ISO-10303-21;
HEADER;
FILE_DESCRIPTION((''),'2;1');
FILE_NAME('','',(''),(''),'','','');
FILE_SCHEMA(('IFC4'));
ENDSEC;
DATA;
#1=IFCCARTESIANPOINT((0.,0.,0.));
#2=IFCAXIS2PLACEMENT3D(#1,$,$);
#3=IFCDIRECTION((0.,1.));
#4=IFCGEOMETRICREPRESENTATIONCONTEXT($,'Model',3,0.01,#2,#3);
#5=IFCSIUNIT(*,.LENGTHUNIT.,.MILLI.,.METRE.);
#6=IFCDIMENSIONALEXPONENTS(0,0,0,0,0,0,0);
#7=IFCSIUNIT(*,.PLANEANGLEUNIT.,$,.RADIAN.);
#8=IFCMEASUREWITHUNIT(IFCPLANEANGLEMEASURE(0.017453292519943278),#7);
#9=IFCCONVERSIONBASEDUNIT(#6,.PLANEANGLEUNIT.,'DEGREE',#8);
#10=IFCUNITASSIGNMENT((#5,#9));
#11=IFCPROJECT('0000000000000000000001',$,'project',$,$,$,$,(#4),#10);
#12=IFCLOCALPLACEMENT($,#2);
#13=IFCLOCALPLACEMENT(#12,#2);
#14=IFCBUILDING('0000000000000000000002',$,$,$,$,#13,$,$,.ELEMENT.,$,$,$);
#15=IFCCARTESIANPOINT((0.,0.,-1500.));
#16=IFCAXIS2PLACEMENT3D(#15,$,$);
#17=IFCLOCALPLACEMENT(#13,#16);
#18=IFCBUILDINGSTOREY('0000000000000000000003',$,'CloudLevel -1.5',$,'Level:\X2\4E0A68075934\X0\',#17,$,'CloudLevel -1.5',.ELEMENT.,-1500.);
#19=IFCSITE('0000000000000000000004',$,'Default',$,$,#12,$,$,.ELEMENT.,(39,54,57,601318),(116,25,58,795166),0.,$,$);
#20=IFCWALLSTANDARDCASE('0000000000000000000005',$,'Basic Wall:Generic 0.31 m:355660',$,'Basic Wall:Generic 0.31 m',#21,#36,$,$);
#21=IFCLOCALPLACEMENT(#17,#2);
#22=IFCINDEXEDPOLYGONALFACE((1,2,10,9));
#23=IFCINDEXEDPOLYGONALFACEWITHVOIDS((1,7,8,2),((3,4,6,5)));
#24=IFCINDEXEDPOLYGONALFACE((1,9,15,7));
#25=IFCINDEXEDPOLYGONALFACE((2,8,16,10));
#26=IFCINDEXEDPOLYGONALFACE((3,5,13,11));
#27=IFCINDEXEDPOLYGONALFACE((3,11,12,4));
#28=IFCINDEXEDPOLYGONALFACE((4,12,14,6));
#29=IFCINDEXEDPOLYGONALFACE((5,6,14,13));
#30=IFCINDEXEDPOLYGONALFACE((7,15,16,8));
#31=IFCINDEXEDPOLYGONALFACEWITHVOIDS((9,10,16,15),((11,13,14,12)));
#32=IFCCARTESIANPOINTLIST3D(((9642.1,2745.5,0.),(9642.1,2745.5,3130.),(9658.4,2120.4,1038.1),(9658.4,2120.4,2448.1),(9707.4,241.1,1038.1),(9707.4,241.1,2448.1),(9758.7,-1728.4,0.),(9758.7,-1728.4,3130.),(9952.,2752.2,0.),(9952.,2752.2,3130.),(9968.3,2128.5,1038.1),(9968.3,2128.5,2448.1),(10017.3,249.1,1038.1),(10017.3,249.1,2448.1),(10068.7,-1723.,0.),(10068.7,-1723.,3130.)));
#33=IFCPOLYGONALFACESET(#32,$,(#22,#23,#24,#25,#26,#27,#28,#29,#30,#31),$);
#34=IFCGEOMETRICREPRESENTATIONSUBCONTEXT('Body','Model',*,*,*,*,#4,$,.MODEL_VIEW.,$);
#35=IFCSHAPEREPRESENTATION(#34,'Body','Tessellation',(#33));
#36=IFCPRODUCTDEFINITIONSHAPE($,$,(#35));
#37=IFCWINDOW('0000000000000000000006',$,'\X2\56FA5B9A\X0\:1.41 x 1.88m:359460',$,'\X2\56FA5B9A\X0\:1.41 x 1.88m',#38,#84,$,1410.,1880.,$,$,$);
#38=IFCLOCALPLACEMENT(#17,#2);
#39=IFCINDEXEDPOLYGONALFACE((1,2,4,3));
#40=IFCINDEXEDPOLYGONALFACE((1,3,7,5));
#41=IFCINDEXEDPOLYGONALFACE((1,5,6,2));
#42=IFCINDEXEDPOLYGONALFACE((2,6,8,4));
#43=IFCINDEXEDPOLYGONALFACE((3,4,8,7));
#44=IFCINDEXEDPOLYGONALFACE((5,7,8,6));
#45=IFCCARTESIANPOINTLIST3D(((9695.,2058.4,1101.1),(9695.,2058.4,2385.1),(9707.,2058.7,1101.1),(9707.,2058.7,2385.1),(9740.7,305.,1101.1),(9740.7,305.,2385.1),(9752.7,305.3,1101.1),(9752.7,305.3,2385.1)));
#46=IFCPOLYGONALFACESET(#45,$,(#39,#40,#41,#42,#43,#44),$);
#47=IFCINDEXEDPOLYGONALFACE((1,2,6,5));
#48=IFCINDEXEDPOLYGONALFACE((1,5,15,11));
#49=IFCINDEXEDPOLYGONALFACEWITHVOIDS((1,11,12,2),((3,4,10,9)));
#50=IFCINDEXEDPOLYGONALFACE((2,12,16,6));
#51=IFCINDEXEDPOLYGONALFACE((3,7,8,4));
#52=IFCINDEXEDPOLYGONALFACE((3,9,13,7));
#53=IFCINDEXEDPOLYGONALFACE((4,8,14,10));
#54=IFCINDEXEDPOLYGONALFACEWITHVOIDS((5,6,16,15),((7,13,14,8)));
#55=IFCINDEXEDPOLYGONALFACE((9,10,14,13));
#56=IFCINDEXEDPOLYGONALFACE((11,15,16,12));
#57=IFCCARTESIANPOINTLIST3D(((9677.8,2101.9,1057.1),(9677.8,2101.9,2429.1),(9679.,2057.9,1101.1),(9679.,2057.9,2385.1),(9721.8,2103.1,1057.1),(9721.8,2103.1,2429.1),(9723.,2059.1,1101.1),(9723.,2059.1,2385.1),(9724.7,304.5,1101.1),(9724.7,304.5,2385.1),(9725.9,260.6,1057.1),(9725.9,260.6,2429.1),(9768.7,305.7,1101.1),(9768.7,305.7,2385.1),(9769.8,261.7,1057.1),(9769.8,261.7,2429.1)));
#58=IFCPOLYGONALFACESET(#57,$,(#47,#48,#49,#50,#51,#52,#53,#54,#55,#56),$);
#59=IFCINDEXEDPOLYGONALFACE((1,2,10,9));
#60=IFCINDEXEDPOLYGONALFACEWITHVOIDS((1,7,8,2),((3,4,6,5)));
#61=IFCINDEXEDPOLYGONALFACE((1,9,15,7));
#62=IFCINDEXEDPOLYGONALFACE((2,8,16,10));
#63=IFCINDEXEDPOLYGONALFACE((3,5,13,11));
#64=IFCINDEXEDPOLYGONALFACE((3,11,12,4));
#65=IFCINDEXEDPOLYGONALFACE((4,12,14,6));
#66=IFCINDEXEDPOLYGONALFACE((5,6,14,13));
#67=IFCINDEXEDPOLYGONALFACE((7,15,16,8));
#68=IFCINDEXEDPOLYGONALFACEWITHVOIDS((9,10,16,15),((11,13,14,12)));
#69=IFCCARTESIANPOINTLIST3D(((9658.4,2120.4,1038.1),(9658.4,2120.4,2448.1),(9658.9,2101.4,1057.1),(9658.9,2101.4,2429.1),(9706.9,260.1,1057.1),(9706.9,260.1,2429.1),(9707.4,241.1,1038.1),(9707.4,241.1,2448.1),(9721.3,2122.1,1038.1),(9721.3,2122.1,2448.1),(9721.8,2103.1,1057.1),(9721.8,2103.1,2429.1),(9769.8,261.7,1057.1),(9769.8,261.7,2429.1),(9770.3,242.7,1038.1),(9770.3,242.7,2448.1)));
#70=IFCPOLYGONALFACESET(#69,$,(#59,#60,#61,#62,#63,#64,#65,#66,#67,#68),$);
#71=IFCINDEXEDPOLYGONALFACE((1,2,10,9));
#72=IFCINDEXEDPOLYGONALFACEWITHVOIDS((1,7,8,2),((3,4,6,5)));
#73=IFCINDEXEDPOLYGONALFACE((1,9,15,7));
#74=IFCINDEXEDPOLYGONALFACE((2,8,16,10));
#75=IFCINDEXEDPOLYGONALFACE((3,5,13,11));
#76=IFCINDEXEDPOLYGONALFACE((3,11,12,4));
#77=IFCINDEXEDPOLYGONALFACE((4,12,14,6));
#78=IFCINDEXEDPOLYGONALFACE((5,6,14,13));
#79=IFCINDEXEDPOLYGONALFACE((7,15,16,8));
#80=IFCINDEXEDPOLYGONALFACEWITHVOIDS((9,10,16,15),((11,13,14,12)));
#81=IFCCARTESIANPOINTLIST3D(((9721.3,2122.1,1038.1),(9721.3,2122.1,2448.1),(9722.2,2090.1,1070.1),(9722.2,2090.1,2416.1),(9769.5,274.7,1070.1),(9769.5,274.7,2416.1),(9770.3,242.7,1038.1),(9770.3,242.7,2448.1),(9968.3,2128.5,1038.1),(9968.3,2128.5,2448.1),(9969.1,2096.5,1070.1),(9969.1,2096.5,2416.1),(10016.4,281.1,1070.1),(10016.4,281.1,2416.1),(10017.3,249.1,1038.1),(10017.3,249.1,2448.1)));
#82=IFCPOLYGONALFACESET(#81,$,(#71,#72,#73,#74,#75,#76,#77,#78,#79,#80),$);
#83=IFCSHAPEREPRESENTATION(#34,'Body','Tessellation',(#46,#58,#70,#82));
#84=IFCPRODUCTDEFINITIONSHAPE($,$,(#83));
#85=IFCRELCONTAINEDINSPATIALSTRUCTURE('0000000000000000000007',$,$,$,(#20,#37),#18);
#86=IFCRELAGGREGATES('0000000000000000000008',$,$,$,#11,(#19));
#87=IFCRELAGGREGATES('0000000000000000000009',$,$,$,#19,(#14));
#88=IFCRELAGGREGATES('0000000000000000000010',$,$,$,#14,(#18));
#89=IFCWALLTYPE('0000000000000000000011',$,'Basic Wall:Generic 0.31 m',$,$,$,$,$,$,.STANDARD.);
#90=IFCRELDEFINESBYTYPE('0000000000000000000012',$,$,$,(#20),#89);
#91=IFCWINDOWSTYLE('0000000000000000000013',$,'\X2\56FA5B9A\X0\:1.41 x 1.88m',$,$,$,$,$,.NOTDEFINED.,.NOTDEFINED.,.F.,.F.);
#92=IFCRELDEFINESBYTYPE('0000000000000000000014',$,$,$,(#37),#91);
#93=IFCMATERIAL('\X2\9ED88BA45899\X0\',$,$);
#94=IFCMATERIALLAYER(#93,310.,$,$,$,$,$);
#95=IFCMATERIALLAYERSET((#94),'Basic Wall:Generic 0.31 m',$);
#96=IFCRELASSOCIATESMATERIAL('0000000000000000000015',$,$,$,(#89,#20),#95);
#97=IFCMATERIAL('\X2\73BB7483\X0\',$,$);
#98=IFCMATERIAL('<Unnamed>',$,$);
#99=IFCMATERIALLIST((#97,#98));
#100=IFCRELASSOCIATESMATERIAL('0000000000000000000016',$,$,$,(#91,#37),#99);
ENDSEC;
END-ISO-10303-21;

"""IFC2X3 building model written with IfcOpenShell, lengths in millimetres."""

from ifc_helpers import new_model, entity, si_unit, converted_unit, direction, frame, frame_2d, origin, place, context, subcontext, project, spatial, polyline, rectangle, outline, extrude, source, transform, mapped, material, material_list, layer, layer_set, layer_usage, type_object, type_shapes, element, fill, save


model = new_model("IFC2X3")

# Units and contexts
model_context = context("Model", 3, precision=0.01, world=origin(), true_north=direction((0.0, 1.0)))
body_context = subcontext(model_context, "Body", "Model", "MODEL_VIEW")
ifc_project = project(units=[si_unit("LENGTHUNIT", "METRE", prefix="MILLI"), converted_unit("PLANEANGLEUNIT", "DEGREE", entity("IfcPlaneAngleMeasure", 0.017453292519943278), si_unit("PLANEANGLEUNIT", "RADIAN"), dimensions=[0, 0, 0, 0, 0, 0, 0])], contexts=[model_context])

# Site, building, storey
site_placement = place(None, origin())
site = spatial("IfcSite", under=ifc_project, at=site_placement, Name="Default", CompositionType="ELEMENT", RefLatitude=(39, 54, 57, 601318), RefLongitude=(116, 25, 58, 795166), RefElevation=0.0)
building_placement = place(site_placement, origin())
building = spatial("IfcBuilding", under=site, at=building_placement, CompositionType="ELEMENT")
storey_placement = place(building_placement, frame((0.0, 0.0, -1500.0)))
storey = spatial("IfcBuildingStorey", under=building, at=storey_placement, Name="CloudLevel -1.5", ObjectType="Level:上标头", LongName="CloudLevel -1.5", CompositionType="ELEMENT", Elevation=-1500.0)

# Shared definitions
ifc_material_1 = material(Name="默认墙")

# Shared definitions
ifc_material_2 = material(Name="玻璃")
ifc_material_3 = material(Name="<Unnamed>")
ifc_material_list_1 = material_list([ifc_material_2, ifc_material_3])

# Wall, opening, window
ifc_layer_1 = layer(ifc_material_1, 310.0)
ifc_layer_set_1 = layer_set([ifc_layer_1], Name="Basic Wall:Generic 0.31 m")
ifc_layer_usage_1 = layer_usage(ifc_layer_set_1, "AXIS2", "NEGATIVE", 155.0)
wall_type_1 = type_object("IfcWallType", Name="Basic Wall:Generic 0.31 m", PredefinedType="STANDARD", material=ifc_layer_set_1)
wall_1_placement = place(storey_placement, frame((9797.0, 2749.6, 0.0), z_axis=(0.0, 0.0, 1.0), x_axis=(0.026065, -0.99966, 0.0)))
wall_1 = element("IfcWallStandardCase", 1, at=wall_1_placement, inside=storey, type_object=wall_type_1, material=ifc_layer_usage_1, Name="Basic Wall:Generic 0.31 m:355660", ObjectType="Basic Wall:Generic 0.31 m", context=body_context, shape_type="SweptSolid", body=[
    extrude(outline(polyline([(4475.4, -155.0), (4478.2, 155.0), (3217.3, 155.0), (2977.1, 155.0), (1.4, 155.0), (0.0, -155.0), (4475.4, -155.0)])), origin(), (0.0, 0.0, 1.0), 3130.0),
])
opening_1_placement = place(wall_1_placement, frame((2505.3, 155.0, 1038.1)))
opening_1 = element("IfcOpeningElement", 2, at=opening_1_placement, cuts=wall_1, ObjectType="Opening", context=body_context, shape_type="SweptSolid", body=[
    extrude(rectangle(XDim=1410.0, YDim=1880.0, at=frame_2d((705.0, 940.0), x_axis=(1.0, 0.0))), frame((0.0, 0.0, 0.0), z_axis=(0.0, -1.0, 0.0), x_axis=(0.0, 0.0, 1.0)), (0.0, 0.0, 1.0), 310.0),
])
window_style_1 = type_object("IfcWindowStyle", Name="固定:1.41 x 1.88m", ConstructionType="NOTDEFINED", OperationType="NOTDEFINED", ParameterTakesPrecedence=False, Sizeable=False, material=ifc_material_list_1)
shared_shape_1 = source(origin(), body_context, "Body", "SweptSolid", [
    extrude(rectangle(XDim=1754.0, YDim=12.0, at=frame_2d((0.0, 0.0), x_axis=(1.0, 0.0))), frame((940.0, 295.0, 63.0), z_axis=(0.0, 0.0, 1.0), x_axis=(-1.0, 0.0, 0.0)), (0.0, 0.0, 1.0), 1284.0),
    extrude(outline(polyline([(-921.0, -686.0), (921.0, -686.0), (921.0, 686.0), (-921.0, 686.0), (-921.0, -686.0)]), holes=[polyline([(-877.0, -642.0), (-877.0, 642.0), (877.0, 642.0), (877.0, -642.0), (-877.0, -642.0)])]), frame((940.0, 317.0, 705.0), z_axis=(0.0, -1.0, 0.0), x_axis=(-1.0, 0.0, 0.0)), (0.0, 0.0, 1.0), 44.0),
    extrude(outline(polyline([(-940.0, -705.0), (940.0, -705.0), (940.0, 705.0), (-940.0, 705.0), (-940.0, -705.0)]), holes=[polyline([(-921.0, -686.0), (-921.0, 686.0), (921.0, 686.0), (921.0, -686.0), (-921.0, -686.0)])]), frame((940.0, 336.0, 705.0), z_axis=(0.0, -1.0, 0.0), x_axis=(-1.0, 0.0, 0.0)), (0.0, 0.0, 1.0), 63.0),
    extrude(outline(polyline([(-940.0, -705.0), (940.0, -705.0), (940.0, 705.0), (-940.0, 705.0), (-940.0, -705.0)]), holes=[polyline([(-908.0, -673.0), (-908.0, 673.0), (908.0, 673.0), (908.0, -673.0), (-908.0, -673.0)])]), frame((940.0, 273.0, 705.0), z_axis=(0.0, -1.0, 0.0), x_axis=(-1.0, 0.0, 0.0)), (0.0, 0.0, 1.0), 247.0),
])
type_shapes(window_style_1, [shared_shape_1])
window_1_placement = place(opening_1_placement, frame((0.0, 26.0, 0.0), z_axis=(0.0, 0.0, 1.0), x_axis=(-1.0, 0.0, 0.0)))
window_1 = element("IfcWindow", 3, at=window_1_placement, inside=storey, type_object=window_style_1, material=ifc_material_list_1, Name="固定:1.41 x 1.88m:359460", ObjectType="固定:1.41 x 1.88m", OverallHeight=1410.0, OverallWidth=1880.0, context=body_context, shape_type="MappedRepresentation", body=[
    mapped(shared_shape_1, transform((0.0, 0.0, 0.0), scale=1.0)),
])
fill(opening_1, window_1)

save(model, "model.ifc")
